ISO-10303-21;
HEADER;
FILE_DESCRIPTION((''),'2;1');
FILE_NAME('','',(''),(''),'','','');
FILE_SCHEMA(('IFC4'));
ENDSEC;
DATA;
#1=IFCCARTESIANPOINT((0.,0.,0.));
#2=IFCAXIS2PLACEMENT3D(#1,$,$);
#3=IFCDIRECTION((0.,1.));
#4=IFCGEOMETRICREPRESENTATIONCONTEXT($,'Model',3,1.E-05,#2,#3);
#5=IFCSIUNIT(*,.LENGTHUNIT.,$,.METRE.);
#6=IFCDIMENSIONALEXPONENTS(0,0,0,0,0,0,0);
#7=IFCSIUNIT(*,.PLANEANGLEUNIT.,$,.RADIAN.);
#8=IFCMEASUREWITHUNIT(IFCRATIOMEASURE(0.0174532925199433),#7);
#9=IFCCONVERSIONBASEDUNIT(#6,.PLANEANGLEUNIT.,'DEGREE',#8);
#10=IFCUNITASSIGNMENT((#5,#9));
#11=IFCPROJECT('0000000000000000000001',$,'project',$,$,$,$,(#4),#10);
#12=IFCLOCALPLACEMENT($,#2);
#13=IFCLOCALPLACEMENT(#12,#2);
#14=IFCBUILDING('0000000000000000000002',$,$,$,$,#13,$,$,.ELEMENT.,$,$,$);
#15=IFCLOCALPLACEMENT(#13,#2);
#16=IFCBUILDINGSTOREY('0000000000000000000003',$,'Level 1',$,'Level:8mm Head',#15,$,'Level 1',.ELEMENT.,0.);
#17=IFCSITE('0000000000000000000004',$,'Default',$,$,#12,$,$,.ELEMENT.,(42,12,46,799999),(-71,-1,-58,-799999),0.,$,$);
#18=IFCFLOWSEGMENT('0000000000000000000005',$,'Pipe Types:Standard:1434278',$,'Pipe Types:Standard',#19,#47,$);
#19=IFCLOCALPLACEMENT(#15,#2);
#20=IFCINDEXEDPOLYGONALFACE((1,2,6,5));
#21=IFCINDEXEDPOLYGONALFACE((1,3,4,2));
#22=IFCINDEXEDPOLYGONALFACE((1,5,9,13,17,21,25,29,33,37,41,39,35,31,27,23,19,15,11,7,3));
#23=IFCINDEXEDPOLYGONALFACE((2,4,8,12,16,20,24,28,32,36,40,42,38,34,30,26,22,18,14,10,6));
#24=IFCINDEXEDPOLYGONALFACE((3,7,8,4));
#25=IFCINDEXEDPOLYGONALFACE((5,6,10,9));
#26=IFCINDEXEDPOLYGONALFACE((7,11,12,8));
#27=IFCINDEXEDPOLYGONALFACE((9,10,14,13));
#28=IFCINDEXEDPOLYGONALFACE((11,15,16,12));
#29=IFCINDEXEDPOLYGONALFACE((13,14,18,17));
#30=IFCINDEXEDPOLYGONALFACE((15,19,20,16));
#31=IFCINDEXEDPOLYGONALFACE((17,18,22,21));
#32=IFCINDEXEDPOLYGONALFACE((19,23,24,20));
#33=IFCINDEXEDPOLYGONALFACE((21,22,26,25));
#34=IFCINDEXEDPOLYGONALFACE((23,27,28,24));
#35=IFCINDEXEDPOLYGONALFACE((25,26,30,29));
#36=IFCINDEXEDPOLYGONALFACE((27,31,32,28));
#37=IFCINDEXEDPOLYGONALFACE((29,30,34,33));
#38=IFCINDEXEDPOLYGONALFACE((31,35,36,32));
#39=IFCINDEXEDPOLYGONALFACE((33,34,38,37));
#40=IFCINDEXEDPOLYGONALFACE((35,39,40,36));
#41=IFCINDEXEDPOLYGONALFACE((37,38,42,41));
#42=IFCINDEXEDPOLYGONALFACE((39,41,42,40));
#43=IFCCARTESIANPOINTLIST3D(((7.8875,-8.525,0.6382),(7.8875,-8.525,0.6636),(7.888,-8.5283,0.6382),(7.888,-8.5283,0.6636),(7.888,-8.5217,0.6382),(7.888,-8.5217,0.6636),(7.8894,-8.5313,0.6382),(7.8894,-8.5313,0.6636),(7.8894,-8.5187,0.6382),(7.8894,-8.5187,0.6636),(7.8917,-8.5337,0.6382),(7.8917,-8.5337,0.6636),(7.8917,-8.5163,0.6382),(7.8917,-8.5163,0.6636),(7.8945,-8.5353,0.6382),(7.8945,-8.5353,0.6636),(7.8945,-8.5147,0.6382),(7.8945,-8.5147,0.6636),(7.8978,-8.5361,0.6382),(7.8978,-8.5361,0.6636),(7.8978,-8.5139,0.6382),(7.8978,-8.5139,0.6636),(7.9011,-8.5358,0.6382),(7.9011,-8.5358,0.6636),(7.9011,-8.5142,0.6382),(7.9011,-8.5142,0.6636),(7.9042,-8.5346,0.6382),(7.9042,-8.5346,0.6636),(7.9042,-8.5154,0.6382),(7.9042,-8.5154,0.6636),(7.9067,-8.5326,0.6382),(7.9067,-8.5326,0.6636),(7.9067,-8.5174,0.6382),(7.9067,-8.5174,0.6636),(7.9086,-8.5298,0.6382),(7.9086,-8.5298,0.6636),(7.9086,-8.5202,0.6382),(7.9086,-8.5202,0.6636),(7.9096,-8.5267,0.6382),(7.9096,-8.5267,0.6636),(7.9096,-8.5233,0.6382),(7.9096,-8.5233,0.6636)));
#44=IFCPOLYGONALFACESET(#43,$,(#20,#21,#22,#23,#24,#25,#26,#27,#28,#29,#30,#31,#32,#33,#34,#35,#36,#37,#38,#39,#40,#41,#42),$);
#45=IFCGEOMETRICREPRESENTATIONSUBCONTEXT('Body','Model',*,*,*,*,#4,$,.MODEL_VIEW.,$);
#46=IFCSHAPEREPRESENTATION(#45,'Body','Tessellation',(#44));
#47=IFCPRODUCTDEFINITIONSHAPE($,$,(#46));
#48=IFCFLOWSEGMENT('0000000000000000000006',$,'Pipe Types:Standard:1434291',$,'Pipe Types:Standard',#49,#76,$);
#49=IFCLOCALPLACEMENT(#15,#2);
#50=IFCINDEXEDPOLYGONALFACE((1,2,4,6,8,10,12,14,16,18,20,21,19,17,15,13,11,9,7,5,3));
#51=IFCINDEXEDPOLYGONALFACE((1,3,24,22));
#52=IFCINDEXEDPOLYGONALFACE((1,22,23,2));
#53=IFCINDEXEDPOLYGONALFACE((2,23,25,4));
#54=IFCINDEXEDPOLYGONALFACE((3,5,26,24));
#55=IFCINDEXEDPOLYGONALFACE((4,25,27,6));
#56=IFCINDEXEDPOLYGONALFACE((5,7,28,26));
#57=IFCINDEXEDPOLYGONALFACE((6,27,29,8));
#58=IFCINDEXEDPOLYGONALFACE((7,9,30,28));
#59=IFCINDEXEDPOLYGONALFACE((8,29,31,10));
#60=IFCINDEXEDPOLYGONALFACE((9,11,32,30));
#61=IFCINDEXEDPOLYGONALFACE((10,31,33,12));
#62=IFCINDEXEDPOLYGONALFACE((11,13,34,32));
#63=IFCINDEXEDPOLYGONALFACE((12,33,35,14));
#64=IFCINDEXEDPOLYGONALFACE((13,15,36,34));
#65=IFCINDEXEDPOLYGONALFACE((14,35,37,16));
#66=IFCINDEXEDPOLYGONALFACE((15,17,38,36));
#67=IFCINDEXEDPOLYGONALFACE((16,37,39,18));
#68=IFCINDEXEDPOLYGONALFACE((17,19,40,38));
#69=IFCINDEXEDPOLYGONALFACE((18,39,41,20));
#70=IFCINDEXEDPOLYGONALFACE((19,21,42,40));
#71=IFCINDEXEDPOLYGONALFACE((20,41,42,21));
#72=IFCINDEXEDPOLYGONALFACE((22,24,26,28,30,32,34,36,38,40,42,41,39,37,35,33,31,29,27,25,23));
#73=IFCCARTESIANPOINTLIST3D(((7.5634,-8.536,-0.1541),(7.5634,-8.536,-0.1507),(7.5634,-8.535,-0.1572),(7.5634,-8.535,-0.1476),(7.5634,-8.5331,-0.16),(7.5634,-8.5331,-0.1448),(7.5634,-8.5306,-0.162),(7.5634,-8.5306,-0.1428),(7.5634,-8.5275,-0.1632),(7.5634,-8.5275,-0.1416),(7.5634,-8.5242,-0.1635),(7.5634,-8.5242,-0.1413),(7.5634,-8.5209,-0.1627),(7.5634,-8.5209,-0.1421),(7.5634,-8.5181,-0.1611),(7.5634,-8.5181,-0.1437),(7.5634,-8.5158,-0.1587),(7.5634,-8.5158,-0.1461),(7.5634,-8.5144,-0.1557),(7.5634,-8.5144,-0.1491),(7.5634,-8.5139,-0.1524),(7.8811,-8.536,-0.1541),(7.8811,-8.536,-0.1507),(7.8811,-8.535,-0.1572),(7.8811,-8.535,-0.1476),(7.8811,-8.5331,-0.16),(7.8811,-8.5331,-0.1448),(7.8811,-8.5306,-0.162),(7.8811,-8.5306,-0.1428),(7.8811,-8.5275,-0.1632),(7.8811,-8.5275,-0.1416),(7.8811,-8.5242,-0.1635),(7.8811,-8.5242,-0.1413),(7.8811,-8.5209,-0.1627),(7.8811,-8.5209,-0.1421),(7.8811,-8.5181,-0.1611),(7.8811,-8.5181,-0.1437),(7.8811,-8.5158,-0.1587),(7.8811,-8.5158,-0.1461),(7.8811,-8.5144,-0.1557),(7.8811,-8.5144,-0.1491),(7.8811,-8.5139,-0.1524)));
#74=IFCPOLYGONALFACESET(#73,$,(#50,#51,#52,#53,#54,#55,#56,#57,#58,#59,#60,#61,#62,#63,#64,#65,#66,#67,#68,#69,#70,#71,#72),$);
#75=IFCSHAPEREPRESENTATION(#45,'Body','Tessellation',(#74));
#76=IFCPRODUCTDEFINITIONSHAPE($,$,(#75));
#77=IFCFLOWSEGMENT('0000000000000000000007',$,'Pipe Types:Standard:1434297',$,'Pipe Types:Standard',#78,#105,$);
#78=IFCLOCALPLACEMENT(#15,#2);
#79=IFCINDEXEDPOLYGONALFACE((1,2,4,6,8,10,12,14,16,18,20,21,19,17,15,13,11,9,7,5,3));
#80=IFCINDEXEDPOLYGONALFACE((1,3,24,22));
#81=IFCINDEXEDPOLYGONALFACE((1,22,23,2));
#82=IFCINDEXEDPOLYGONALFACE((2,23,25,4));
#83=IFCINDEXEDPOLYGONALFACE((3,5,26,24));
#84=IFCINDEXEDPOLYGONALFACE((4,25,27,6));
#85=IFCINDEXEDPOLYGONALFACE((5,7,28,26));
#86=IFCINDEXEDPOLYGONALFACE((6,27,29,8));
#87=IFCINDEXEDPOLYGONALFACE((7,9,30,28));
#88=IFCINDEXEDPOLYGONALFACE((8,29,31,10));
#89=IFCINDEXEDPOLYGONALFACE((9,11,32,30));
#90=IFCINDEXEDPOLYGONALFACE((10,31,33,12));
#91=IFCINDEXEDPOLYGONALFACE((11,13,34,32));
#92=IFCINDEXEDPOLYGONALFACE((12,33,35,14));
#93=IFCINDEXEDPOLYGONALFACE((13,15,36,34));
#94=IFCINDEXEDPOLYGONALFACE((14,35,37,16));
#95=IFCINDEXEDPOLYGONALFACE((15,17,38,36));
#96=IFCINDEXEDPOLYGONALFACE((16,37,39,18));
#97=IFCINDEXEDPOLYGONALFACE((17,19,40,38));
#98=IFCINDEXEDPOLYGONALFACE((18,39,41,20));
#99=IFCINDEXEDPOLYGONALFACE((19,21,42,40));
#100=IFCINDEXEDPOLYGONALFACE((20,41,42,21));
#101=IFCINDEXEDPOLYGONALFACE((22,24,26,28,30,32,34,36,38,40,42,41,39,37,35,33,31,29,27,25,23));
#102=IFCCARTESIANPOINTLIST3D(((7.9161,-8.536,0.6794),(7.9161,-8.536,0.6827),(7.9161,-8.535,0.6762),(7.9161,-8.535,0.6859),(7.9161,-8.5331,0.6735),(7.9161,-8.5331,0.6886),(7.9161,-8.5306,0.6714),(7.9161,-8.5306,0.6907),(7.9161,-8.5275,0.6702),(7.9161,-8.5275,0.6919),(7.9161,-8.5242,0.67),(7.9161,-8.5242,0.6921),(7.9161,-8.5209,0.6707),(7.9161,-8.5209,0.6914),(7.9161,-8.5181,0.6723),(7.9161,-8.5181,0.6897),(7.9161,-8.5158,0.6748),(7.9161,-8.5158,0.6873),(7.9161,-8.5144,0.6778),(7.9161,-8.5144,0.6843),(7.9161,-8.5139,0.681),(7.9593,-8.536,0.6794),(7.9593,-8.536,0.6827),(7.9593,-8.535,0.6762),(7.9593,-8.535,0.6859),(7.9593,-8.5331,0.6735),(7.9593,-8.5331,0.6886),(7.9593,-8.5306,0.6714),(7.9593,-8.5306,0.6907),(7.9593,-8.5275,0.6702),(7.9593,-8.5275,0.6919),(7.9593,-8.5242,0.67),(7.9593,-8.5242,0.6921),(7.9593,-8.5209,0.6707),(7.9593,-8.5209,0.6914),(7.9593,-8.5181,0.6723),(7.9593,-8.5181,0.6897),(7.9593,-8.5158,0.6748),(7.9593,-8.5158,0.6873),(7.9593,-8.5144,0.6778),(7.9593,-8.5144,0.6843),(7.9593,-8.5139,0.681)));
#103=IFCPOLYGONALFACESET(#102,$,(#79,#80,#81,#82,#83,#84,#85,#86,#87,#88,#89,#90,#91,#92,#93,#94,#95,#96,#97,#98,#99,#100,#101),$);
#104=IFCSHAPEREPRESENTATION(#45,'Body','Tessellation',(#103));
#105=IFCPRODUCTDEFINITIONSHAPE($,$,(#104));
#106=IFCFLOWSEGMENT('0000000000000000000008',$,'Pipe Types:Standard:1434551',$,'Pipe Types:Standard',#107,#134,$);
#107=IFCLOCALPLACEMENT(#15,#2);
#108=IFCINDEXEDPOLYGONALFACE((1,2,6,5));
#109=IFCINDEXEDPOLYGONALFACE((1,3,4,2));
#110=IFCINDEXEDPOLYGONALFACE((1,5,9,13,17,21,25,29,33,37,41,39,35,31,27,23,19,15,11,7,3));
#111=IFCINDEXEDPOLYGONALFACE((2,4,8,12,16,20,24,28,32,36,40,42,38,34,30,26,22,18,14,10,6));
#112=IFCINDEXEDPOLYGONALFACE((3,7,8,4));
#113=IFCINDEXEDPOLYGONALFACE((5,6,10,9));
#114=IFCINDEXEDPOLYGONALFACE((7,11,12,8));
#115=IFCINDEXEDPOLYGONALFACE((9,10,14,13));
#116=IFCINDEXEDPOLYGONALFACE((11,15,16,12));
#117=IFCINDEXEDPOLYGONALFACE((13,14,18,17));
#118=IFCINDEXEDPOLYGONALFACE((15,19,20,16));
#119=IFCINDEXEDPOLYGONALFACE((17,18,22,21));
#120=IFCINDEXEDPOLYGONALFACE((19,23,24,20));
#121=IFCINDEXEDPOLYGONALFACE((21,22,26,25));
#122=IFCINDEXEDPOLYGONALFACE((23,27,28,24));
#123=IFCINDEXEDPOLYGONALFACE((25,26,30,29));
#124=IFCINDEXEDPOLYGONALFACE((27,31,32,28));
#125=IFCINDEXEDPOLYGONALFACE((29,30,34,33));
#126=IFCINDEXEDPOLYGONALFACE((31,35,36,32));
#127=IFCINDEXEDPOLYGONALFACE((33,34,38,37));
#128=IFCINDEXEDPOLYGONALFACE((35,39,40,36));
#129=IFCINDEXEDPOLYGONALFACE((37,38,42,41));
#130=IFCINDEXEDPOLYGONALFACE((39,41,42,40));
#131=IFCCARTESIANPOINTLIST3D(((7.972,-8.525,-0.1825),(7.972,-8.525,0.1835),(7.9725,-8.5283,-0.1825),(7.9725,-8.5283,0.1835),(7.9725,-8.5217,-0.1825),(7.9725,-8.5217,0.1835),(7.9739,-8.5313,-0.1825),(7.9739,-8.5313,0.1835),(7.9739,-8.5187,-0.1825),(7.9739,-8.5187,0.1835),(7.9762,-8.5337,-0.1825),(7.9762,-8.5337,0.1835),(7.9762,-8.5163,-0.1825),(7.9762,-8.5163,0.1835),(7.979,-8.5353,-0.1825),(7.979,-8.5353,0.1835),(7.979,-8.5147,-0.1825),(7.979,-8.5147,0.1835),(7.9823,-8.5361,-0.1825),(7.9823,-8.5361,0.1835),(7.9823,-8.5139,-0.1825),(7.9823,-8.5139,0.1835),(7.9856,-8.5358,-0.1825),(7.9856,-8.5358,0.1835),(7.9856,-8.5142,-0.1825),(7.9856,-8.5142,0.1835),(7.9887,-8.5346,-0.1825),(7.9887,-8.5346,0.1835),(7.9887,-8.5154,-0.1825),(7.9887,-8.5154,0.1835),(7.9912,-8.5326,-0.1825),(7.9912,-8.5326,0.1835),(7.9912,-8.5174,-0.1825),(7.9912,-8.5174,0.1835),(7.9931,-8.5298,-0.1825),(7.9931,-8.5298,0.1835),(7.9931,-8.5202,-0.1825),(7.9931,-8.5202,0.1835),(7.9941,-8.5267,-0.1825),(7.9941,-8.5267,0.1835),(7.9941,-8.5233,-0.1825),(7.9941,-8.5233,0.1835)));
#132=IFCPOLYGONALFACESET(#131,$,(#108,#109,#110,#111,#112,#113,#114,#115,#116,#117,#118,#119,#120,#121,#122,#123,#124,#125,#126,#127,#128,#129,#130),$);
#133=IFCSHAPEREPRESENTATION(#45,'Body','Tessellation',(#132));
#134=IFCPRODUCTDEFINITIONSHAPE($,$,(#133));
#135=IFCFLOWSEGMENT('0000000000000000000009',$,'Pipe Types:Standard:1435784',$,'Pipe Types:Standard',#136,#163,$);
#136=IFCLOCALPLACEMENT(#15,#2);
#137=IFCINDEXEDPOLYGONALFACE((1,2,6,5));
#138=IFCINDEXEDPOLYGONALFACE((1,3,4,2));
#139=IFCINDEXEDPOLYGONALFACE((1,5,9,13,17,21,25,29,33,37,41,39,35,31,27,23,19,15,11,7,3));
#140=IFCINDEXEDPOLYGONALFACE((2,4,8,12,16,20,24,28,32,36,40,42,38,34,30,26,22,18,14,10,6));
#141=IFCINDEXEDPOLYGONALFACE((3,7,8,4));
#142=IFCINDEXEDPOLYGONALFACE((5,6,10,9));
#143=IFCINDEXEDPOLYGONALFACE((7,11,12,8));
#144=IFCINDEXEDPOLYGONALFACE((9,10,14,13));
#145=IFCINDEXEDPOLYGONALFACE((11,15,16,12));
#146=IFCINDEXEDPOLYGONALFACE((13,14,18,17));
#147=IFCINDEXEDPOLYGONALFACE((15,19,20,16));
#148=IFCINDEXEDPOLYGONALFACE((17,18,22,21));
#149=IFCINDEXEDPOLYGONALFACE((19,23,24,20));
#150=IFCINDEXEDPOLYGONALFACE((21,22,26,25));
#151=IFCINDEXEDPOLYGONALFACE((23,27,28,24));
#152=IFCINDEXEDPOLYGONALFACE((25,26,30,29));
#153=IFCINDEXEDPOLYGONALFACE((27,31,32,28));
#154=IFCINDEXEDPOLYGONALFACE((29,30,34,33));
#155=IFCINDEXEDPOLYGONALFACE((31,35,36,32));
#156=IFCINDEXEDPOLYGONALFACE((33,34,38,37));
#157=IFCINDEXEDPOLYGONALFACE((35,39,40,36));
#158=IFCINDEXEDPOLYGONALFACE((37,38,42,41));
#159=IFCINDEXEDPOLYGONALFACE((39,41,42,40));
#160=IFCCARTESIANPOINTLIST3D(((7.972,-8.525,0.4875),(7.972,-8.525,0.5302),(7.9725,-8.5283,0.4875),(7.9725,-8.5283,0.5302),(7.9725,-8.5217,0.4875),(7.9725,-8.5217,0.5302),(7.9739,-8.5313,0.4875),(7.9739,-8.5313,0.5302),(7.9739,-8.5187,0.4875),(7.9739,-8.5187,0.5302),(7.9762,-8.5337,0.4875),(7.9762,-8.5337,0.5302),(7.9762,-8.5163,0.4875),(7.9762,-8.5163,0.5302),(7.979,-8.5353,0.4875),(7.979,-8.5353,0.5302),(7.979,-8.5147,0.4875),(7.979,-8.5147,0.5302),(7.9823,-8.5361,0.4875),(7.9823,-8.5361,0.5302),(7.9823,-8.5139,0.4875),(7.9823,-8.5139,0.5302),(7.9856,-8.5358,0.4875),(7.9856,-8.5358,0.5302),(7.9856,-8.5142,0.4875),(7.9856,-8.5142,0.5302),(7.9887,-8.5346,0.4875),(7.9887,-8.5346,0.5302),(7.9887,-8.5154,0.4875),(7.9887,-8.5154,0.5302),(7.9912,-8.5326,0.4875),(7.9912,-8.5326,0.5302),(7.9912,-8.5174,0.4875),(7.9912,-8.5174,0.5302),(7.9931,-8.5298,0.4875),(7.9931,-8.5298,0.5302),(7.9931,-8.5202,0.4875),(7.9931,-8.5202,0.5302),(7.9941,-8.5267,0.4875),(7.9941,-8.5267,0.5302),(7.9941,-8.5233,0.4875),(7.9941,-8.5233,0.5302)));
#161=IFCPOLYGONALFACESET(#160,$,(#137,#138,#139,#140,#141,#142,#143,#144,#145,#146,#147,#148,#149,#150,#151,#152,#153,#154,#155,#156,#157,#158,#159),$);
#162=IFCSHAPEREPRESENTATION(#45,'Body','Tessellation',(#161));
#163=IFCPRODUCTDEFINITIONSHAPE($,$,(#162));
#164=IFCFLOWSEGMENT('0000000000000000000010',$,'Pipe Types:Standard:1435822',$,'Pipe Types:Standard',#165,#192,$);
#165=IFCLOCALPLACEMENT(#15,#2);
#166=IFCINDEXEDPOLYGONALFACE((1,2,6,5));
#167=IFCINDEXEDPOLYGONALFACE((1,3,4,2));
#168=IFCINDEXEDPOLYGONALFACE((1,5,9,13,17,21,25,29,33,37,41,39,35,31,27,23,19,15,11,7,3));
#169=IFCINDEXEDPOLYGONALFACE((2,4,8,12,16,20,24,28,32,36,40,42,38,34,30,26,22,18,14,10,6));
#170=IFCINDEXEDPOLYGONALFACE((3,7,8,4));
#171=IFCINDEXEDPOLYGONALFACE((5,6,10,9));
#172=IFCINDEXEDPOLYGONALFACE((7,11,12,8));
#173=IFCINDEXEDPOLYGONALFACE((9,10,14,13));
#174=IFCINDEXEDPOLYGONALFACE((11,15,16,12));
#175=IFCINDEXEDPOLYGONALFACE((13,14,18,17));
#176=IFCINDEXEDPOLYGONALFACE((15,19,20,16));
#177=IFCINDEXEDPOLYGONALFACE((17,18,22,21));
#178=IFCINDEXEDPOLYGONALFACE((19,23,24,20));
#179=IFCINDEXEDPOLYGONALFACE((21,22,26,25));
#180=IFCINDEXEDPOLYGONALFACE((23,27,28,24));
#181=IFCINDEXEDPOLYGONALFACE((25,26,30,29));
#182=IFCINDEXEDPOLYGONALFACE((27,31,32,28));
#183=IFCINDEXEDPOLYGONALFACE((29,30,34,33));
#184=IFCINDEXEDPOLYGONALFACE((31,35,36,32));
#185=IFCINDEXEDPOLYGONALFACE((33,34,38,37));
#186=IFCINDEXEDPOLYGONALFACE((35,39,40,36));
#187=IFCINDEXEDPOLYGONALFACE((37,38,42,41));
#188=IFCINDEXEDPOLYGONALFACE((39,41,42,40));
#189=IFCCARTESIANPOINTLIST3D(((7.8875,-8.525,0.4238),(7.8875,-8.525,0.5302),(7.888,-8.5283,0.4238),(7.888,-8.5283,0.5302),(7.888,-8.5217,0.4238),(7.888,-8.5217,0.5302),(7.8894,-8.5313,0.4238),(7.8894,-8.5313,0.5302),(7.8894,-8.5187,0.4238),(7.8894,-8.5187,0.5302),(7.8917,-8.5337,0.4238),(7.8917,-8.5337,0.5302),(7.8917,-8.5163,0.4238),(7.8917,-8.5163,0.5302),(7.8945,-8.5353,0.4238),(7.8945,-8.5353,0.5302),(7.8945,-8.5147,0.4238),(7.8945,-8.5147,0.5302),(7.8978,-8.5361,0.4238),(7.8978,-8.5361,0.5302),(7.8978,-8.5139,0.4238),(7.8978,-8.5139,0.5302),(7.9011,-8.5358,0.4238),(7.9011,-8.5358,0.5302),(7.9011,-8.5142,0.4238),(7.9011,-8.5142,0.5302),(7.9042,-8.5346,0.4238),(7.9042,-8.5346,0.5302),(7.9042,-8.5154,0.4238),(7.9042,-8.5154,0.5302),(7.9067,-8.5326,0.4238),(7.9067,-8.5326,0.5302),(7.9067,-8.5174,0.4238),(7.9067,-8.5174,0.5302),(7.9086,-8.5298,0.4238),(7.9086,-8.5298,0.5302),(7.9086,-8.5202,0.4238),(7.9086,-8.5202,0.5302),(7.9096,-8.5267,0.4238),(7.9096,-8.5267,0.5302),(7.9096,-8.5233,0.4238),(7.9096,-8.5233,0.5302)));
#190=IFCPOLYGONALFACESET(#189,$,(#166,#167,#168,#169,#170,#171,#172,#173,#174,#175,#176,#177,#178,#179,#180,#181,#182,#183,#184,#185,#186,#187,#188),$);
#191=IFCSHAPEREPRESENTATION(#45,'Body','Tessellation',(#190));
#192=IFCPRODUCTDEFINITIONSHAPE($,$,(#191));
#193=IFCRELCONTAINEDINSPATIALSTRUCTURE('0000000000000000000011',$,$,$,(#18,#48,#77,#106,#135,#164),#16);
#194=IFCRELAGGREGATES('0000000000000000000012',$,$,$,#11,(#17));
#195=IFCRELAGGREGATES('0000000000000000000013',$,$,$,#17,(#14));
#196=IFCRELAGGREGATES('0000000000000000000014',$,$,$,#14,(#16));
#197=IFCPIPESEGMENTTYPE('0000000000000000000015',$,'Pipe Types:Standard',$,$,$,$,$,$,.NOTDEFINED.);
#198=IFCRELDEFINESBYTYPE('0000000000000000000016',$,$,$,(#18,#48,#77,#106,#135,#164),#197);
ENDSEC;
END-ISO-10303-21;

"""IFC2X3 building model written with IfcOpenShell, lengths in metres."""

from ifc_helpers import new_model, entity, si_unit, converted_unit, direction, frame, frame_2d, origin, origin_2d_with_axis, place, context, subcontext, project, spatial, circle, extrude, type_object, element, save


model = new_model("IFC2X3")

# Units and contexts
model_context = context("Model", 3, precision=1e-05, world=origin(), true_north=direction((0.0, 1.0)))
body_context = subcontext(model_context, "Body", "Model", "MODEL_VIEW")
ifc_project = project(units=[si_unit("LENGTHUNIT", "METRE"), converted_unit("PLANEANGLEUNIT", "DEGREE", entity("IfcRatioMeasure", 0.0174532925199433), si_unit("PLANEANGLEUNIT", "RADIAN"), dimensions=[0, 0, 0, 0, 0, 0, 0])], contexts=[model_context])

# Site, building, storey
site_placement = place(None, origin())
site = spatial("IfcSite", under=ifc_project, at=site_placement, Name="Default", CompositionType="ELEMENT", RefLatitude=(42, 12, 46, 799999), RefLongitude=(-71, -1, -58, -799999), RefElevation=0.0)
building_placement = place(site_placement, origin())
building = spatial("IfcBuilding", under=site, at=building_placement, CompositionType="ELEMENT")
storey_placement = place(building_placement, origin())
storey = spatial("IfcBuildingStorey", under=building, at=storey_placement, Name="Level 1", ObjectType="Level:8mm Head", LongName="Level 1", CompositionType="ELEMENT", Elevation=0.0)

# Flow segments
pipe_segment_type = type_object("IfcPipeSegmentType", Name="Pipe Types:Standard", PredefinedType="NOTDEFINED")
flow_segment_1_placement = place(storey_placement, origin())
element("IfcFlowSegment", 1, at=flow_segment_1_placement, inside=storey, type_object=pipe_segment_type, Name="Pipe Types:Standard:1434278", ObjectType="Pipe Types:Standard", context=body_context, shape_type="SweptSolid", body=[
    extrude(circle(Radius=0.0111, at=frame_2d((0.0, 0.0), x_axis=(1.0, 0.0))), frame((7.8986, -8.525, 0.6382), z_axis=(0.0, 0.0, 1.0), x_axis=(-1.0, 0.0, 0.0)), (0.0, 0.0, 1.0), 0.0253),
])
flow_segment_2_placement = place(storey_placement, origin())
element("IfcFlowSegment", 2, at=flow_segment_2_placement, inside=storey, type_object=pipe_segment_type, Name="Pipe Types:Standard:1434291", ObjectType="Pipe Types:Standard", context=body_context, shape_type="SweptSolid", body=[
    extrude(circle(Radius=0.0111, at=frame_2d((0.0, 0.0), x_axis=(1.0, 0.0))), frame((7.5634, -8.525, -0.1524), z_axis=(1.0, 0.0, 0.0), x_axis=(0.0, 1.0, 0.0)), (0.0, 0.0, 1.0), 0.3177),
])
flow_segment_3_placement = place(storey_placement, origin())
element("IfcFlowSegment", 3, at=flow_segment_3_placement, inside=storey, type_object=pipe_segment_type, Name="Pipe Types:Standard:1434297", ObjectType="Pipe Types:Standard", context=body_context, shape_type="SweptSolid", body=[
    extrude(circle(Radius=0.0111, at=frame_2d((0.0, 0.0), x_axis=(1.0, 0.0))), frame((7.9161, -8.525, 0.681), z_axis=(1.0, 0.0, 0.0), x_axis=(0.0, 1.0, 0.0)), (0.0, 0.0, 1.0), 0.0432),
])
flow_segment_4_placement = place(storey_placement, origin())
element("IfcFlowSegment", 4, at=flow_segment_4_placement, inside=storey, type_object=pipe_segment_type, Name="Pipe Types:Standard:1434551", ObjectType="Pipe Types:Standard", context=body_context, shape_type="SweptSolid", body=[
    extrude(circle(Radius=0.0111, at=origin_2d_with_axis()), frame((7.9831, -8.525, -0.1825), z_axis=(0.0, 0.0, 1.0), x_axis=(-1.0, 0.0, 0.0)), (0.0, 0.0, 1.0), 0.366),
])
flow_segment_5_placement = place(storey_placement, origin())
element("IfcFlowSegment", 5, at=flow_segment_5_placement, inside=storey, type_object=pipe_segment_type, Name="Pipe Types:Standard:1435784", ObjectType="Pipe Types:Standard", context=body_context, shape_type="SweptSolid", body=[
    extrude(circle(Radius=0.0111, at=frame_2d((0.0, 0.0), x_axis=(1.0, 0.0))), frame((7.9831, -8.525, 0.4875), z_axis=(0.0, 0.0, 1.0), x_axis=(-1.0, 0.0, 0.0)), (0.0, 0.0, 1.0), 0.0426),
])
flow_segment_6_placement = place(storey_placement, origin())
element("IfcFlowSegment", 6, at=flow_segment_6_placement, inside=storey, type_object=pipe_segment_type, Name="Pipe Types:Standard:1435822", ObjectType="Pipe Types:Standard", context=body_context, shape_type="SweptSolid", body=[
    extrude(circle(Radius=0.0111, at=frame_2d((0.0, 0.0), x_axis=(1.0, 0.0))), frame((7.8986, -8.525, 0.4238), z_axis=(0.0, 0.0, 1.0), x_axis=(-1.0, 0.0, 0.0)), (0.0, 0.0, 1.0), 0.1063),
])

save(model, "model.ifc")
